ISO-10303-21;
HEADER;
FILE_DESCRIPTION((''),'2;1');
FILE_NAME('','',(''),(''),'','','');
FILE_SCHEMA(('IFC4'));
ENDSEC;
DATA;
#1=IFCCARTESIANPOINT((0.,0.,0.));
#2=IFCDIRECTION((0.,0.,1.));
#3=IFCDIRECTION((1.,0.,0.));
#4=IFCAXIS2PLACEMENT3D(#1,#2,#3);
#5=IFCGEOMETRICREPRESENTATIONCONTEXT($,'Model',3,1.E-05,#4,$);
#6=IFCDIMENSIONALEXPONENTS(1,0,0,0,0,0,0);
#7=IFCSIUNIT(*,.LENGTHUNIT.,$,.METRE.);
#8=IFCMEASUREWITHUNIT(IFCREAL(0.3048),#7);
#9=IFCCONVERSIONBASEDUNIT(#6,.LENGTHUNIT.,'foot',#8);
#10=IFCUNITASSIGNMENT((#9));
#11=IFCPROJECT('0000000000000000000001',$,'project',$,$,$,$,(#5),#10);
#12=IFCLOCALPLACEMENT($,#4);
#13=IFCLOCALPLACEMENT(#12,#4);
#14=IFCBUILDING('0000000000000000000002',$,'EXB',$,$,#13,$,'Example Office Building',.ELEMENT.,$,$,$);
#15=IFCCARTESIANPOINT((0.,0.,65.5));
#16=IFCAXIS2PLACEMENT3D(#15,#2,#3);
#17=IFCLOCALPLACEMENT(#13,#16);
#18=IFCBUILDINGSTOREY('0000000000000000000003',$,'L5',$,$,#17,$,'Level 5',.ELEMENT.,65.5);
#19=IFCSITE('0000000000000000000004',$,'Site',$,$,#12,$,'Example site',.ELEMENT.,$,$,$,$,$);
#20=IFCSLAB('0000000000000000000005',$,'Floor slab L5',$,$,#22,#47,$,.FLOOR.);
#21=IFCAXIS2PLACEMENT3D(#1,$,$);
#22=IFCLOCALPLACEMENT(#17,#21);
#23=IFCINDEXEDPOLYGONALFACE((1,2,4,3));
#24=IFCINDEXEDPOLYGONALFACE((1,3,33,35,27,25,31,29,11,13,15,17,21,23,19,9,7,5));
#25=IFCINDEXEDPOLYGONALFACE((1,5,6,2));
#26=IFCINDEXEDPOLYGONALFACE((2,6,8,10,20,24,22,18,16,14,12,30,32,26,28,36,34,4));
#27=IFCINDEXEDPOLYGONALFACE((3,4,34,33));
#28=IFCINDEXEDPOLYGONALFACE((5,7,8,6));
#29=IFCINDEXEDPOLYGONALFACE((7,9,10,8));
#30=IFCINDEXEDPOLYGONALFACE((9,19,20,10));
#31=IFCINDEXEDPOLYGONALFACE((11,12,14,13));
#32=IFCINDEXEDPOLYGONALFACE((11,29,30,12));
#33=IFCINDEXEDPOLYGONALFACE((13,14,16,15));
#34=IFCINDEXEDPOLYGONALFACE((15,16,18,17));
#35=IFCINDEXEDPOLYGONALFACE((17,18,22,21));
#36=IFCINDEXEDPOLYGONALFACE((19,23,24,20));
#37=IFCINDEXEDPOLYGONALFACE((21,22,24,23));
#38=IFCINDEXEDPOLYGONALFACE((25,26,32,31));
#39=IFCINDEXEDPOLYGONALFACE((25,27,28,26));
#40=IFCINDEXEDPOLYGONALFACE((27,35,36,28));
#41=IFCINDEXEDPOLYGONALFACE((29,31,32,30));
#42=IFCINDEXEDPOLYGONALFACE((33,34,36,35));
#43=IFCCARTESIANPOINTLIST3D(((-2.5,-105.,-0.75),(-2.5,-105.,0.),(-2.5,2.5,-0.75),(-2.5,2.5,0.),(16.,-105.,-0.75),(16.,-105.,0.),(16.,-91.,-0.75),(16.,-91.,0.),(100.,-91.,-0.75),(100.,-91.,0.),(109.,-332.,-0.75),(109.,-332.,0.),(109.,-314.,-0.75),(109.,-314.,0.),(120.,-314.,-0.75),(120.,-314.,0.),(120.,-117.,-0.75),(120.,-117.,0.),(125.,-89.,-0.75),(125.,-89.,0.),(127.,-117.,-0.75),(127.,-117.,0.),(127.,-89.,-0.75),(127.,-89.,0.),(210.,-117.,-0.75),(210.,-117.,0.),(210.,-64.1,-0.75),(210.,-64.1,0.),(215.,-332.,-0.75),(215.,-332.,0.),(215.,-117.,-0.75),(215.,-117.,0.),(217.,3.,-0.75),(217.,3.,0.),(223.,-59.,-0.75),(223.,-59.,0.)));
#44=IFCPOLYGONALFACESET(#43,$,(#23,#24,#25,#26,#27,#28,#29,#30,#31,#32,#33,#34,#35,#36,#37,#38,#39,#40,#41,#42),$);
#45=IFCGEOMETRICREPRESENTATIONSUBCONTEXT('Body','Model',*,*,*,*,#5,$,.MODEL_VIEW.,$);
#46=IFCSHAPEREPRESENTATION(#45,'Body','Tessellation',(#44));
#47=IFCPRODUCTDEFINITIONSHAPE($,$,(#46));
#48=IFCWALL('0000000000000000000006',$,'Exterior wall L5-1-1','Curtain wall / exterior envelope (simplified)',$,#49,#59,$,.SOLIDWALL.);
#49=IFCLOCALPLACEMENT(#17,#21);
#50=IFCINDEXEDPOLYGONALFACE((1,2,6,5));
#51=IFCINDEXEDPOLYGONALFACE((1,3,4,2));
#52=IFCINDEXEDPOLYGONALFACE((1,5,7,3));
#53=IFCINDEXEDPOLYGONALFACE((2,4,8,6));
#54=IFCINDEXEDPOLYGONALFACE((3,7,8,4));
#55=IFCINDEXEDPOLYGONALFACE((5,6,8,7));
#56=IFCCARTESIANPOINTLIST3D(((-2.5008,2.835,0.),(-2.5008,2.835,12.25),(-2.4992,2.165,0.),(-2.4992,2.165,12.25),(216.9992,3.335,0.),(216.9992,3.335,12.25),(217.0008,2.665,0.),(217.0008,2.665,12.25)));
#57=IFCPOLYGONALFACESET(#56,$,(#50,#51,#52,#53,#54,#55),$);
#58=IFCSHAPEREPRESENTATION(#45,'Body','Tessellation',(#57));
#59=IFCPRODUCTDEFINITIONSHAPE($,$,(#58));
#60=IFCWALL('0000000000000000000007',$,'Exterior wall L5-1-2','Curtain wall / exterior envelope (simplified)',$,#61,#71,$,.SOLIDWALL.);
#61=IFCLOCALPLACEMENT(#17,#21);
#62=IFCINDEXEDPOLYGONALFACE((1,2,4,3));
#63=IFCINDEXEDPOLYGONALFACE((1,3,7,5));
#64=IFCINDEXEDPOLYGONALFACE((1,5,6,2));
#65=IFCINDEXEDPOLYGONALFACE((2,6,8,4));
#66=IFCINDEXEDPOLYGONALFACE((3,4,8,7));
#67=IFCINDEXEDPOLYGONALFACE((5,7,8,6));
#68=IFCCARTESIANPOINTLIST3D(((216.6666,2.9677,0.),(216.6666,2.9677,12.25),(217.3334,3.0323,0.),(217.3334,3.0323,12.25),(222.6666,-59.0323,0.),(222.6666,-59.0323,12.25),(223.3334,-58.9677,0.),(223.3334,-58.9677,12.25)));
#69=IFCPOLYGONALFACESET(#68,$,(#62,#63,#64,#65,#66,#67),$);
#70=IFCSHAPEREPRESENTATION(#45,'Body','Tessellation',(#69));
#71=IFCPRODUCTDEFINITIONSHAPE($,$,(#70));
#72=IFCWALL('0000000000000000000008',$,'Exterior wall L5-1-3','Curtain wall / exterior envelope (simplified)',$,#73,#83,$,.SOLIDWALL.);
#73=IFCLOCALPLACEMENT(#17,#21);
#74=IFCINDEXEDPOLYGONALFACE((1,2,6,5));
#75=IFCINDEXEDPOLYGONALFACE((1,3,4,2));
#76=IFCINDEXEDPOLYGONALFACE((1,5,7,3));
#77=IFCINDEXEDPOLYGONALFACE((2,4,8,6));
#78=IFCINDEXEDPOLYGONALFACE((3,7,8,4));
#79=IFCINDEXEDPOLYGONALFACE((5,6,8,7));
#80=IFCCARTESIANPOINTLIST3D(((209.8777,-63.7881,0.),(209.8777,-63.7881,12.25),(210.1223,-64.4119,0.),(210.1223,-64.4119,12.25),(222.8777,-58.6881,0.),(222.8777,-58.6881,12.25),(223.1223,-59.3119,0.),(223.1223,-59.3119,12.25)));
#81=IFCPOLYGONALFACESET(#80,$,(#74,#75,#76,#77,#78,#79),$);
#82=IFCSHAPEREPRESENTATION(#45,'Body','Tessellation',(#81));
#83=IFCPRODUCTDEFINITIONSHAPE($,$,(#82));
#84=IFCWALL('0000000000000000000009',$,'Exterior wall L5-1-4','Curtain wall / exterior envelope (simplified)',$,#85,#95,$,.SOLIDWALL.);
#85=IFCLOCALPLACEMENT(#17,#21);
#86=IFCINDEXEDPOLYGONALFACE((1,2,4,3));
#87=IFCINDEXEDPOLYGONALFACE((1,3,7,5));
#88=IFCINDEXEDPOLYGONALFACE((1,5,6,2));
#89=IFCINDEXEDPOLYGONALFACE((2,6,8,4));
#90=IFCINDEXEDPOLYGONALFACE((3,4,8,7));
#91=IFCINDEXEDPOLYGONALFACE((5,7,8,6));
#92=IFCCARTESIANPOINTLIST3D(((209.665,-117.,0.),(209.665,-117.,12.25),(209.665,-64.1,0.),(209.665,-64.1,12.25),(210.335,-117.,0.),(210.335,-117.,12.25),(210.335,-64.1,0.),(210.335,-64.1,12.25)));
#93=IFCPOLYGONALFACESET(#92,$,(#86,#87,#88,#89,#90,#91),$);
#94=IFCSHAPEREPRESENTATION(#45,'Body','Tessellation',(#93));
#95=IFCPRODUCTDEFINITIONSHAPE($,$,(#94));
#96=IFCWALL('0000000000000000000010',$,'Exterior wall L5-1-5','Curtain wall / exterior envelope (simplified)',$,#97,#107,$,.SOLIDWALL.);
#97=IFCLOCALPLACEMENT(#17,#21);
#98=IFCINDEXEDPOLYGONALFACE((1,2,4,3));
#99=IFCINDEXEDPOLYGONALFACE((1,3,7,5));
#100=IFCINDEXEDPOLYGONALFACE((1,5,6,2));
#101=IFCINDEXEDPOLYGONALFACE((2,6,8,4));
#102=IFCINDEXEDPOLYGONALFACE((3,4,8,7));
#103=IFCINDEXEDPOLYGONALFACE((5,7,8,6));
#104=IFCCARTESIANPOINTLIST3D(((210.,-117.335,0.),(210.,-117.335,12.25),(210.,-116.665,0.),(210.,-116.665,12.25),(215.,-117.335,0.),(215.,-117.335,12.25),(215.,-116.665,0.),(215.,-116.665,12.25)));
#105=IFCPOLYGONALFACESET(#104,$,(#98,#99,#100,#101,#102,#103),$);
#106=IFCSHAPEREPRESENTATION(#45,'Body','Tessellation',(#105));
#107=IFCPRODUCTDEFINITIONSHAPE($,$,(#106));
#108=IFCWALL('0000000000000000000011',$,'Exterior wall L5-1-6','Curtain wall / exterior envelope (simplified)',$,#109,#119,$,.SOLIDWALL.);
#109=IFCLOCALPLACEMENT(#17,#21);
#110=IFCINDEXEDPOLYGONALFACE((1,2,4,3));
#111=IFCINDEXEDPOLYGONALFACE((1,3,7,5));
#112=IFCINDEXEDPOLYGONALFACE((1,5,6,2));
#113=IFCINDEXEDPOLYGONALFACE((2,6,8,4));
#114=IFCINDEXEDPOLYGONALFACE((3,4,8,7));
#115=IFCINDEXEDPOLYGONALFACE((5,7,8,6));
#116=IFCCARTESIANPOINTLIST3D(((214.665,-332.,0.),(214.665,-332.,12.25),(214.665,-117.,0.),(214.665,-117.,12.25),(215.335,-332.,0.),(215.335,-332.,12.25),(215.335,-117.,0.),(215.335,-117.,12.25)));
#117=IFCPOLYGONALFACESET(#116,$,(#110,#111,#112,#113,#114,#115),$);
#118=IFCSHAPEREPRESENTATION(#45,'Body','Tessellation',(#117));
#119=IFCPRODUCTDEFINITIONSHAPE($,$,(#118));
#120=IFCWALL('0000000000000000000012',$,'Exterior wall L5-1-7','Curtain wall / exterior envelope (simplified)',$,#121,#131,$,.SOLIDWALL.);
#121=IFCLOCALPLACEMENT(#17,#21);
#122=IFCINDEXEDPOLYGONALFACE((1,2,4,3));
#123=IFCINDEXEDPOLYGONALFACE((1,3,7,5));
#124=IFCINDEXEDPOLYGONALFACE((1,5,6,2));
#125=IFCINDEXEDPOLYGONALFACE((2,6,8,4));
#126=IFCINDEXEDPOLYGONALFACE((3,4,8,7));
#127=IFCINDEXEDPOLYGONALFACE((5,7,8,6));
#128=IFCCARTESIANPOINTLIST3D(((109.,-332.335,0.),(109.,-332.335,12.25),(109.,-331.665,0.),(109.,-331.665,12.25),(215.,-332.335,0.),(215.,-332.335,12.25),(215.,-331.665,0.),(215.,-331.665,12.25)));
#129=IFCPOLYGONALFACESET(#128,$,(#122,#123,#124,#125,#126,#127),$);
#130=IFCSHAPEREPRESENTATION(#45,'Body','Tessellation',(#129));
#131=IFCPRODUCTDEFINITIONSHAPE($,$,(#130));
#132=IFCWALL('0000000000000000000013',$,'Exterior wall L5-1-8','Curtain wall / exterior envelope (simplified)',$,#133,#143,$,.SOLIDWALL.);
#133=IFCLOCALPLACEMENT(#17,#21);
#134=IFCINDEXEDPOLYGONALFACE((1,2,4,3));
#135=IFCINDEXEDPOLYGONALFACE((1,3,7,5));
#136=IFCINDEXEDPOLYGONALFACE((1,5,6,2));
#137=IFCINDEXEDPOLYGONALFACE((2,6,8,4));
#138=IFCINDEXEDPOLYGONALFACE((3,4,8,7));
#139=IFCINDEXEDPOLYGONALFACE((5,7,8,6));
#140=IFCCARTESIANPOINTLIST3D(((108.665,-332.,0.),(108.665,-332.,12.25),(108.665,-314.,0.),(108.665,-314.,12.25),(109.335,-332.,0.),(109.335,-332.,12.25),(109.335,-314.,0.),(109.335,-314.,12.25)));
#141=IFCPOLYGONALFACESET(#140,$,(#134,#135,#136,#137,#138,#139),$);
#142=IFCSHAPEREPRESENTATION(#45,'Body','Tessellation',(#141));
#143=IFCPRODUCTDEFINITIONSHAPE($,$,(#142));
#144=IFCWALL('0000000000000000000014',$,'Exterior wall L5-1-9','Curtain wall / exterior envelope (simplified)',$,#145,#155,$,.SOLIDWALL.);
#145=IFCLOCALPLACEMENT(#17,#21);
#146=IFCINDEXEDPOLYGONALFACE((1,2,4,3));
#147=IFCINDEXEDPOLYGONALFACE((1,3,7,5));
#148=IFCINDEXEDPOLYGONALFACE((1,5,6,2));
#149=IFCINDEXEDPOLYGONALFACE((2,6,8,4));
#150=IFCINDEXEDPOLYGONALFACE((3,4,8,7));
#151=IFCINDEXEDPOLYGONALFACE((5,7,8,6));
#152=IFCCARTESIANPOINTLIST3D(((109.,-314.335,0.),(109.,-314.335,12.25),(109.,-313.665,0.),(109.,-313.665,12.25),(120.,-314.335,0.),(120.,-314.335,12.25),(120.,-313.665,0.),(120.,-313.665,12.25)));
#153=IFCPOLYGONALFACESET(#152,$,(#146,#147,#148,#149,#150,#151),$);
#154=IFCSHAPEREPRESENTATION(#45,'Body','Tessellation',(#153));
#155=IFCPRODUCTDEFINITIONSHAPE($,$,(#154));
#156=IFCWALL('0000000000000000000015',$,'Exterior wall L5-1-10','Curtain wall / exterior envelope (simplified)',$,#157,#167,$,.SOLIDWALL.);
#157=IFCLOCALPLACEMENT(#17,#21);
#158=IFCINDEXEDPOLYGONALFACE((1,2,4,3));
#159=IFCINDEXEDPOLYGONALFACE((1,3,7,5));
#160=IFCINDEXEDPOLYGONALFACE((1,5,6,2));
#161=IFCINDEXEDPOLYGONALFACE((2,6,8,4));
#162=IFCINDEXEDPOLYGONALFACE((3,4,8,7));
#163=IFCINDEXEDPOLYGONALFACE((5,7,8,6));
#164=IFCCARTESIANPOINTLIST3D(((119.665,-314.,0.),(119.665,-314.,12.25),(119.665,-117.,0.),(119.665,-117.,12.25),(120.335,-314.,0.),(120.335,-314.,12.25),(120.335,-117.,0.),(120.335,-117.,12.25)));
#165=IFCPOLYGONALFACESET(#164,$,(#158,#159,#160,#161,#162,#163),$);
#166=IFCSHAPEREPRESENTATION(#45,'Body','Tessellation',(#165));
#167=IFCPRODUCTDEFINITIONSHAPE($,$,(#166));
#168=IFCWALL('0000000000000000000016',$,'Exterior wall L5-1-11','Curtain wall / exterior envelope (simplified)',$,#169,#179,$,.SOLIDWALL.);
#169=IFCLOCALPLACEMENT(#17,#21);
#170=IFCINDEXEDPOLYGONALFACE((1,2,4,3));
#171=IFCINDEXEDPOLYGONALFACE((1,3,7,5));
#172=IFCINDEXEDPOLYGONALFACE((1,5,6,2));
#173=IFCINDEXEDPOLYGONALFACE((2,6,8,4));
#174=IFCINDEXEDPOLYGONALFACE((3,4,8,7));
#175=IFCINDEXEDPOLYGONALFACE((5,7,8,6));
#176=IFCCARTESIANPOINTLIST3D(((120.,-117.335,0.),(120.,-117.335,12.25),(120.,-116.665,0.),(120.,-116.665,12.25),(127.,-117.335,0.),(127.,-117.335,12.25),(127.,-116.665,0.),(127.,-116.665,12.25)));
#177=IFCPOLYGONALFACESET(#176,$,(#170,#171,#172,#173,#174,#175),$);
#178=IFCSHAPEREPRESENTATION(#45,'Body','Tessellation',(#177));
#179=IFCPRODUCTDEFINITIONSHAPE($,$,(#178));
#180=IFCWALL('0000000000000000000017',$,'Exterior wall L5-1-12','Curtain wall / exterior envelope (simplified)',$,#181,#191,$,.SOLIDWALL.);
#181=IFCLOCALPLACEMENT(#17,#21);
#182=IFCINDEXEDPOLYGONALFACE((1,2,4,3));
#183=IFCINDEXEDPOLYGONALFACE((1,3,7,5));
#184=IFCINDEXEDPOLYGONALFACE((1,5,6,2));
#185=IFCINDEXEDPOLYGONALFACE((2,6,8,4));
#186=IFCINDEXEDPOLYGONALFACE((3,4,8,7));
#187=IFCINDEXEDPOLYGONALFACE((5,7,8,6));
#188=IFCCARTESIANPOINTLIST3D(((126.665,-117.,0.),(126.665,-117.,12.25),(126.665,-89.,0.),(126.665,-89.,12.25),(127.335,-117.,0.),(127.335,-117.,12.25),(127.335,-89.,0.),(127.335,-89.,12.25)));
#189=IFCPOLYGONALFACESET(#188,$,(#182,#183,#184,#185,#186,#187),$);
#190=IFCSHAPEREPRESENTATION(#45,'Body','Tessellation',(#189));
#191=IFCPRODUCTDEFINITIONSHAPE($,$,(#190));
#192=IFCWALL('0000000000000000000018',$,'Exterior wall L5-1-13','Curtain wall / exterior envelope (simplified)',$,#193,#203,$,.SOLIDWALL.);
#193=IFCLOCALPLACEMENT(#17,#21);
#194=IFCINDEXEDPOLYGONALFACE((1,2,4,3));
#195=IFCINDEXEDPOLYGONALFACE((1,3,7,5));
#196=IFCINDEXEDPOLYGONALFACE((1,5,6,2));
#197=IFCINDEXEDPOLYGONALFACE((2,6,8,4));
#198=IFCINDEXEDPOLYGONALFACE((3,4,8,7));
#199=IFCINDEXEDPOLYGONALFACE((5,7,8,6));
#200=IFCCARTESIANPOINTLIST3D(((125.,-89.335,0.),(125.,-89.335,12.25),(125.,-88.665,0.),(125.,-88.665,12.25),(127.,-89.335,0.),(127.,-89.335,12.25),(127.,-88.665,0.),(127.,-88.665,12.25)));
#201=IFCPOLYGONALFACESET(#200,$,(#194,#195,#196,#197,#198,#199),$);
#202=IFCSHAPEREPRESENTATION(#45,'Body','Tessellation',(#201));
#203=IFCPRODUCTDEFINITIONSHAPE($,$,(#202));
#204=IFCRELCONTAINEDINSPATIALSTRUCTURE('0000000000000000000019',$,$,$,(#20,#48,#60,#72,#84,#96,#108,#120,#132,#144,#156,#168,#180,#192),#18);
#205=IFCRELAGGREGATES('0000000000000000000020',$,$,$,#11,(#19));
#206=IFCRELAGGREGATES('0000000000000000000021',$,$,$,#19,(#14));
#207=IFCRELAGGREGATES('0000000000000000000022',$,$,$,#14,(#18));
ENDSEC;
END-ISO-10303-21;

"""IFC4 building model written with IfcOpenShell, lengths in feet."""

from ifc_helpers import new_model, entity, si_unit, converted_unit, frame, frame_2d, origin, origin_with_axes, place, context, subcontext, project, spatial, polyline, rectangle, outline, extrude, element, save


model = new_model("IFC4")

# Units and contexts
model_context = context("Model", 3, precision=1e-05, world=origin_with_axes())
body_context = subcontext(model_context, "Body", "Model", "MODEL_VIEW")
ifc_project = project(units=[converted_unit("LENGTHUNIT", "foot", entity("IfcReal", 0.3048), si_unit("LENGTHUNIT", "METRE"), dimensions=[1, 0, 0, 0, 0, 0, 0])], contexts=[model_context])

# Site, building, storey
site_placement = place(None, origin_with_axes())
site = spatial("IfcSite", under=ifc_project, at=site_placement, Name="Site", LongName="Example site", CompositionType="ELEMENT")
building_placement = place(site_placement, origin_with_axes())
building = spatial("IfcBuilding", under=site, at=building_placement, Name="EXB", LongName="Example Office Building", CompositionType="ELEMENT")
storey_placement = place(building_placement, frame((0.0, 0.0, 65.5), z_axis=(0.0, 0.0, 1.0), x_axis=(1.0, 0.0, 0.0)))
storey = spatial("IfcBuildingStorey", under=building, at=storey_placement, Name="L5", LongName="Level 5", CompositionType="ELEMENT", Elevation=65.5)

# Slab
slab_placement = place(storey_placement, origin_with_axes())
element("IfcSlab", 1, at=slab_placement, inside=storey, Name="Floor slab L5", PredefinedType="FLOOR", context=body_context, shape_type="SweptSolid", body=[
    extrude(outline(polyline([(-2.5, 2.5), (217.0, 3.0), (223.0, -59.0), (210.0, -64.1), (210.0, -117.0), (215.0, -117.0), (215.0, -332.0), (109.0, -332.0), (109.0, -314.0), (120.0, -314.0), (120.0, -117.0), (127.0, -117.0), (127.0, -89.0), (125.0, -89.0), (100.0, -91.0), (16.0, -91.0), (16.0, -105.0), (-2.5, -105.0), (-2.5, 2.5)])), frame((0.0, 0.0, -0.75)), (0.0, 0.0, 1.0), 0.75),
])

# Walls
wall_1_placement = place(storey_placement, frame((-2.5, 2.5, 0.0), z_axis=(0.0, 0.0, 1.0), x_axis=(0.999997, 0.002278, 0.0)))
element("IfcWall", 2, at=wall_1_placement, inside=storey, Name="Exterior wall L5-1-1", Description="Curtain wall / exterior envelope (simplified)", PredefinedType="SOLIDWALL", context=body_context, shape_type="SweptSolid", body=[
    extrude(rectangle(XDim=219.5006, YDim=0.67, at=frame_2d((109.7503, 0.0))), origin(), (0.0, 0.0, 1.0), 12.25),
])
wall_2_placement = place(storey_placement, frame((217.0, 3.0, 0.0), z_axis=(0.0, 0.0, 1.0), x_axis=(0.096324, -0.99535, 0.0)))
element("IfcWall", 3, at=wall_2_placement, inside=storey, Name="Exterior wall L5-1-2", Description="Curtain wall / exterior envelope (simplified)", PredefinedType="SOLIDWALL", context=body_context, shape_type="SweptSolid", body=[
    extrude(rectangle(XDim=62.2896, YDim=0.67, at=frame_2d((31.1448, 0.0))), origin(), (0.0, 0.0, 1.0), 12.25),
])
wall_3_placement = place(storey_placement, frame((223.0, -59.0, 0.0), z_axis=(0.0, 0.0, 1.0), x_axis=(-0.930925, -0.365209, 0.0)))
element("IfcWall", 4, at=wall_3_placement, inside=storey, Name="Exterior wall L5-1-3", Description="Curtain wall / exterior envelope (simplified)", PredefinedType="SOLIDWALL", context=body_context, shape_type="SweptSolid", body=[
    extrude(rectangle(XDim=13.9646, YDim=0.67, at=frame_2d((6.9823, 0.0))), origin(), (0.0, 0.0, 1.0), 12.25),
])
wall_4_placement = place(storey_placement, frame((210.0, -64.1, 0.0), z_axis=(0.0, 0.0, 1.0), x_axis=(0.0, -1.0, 0.0)))
element("IfcWall", 5, at=wall_4_placement, inside=storey, Name="Exterior wall L5-1-4", Description="Curtain wall / exterior envelope (simplified)", PredefinedType="SOLIDWALL", context=body_context, shape_type="SweptSolid", body=[
    extrude(rectangle(XDim=52.9, YDim=0.67, at=frame_2d((26.45, 0.0))), origin(), (0.0, 0.0, 1.0), 12.25),
])
wall_5_placement = place(storey_placement, frame((210.0, -117.0, 0.0), z_axis=(0.0, 0.0, 1.0), x_axis=(1.0, 0.0, 0.0)))
element("IfcWall", 6, at=wall_5_placement, inside=storey, Name="Exterior wall L5-1-5", Description="Curtain wall / exterior envelope (simplified)", PredefinedType="SOLIDWALL", context=body_context, shape_type="SweptSolid", body=[
    extrude(rectangle(XDim=5.0, YDim=0.67, at=frame_2d((2.5, 0.0))), origin(), (0.0, 0.0, 1.0), 12.25),
])
wall_6_placement = place(storey_placement, frame((215.0, -117.0, 0.0), z_axis=(0.0, 0.0, 1.0), x_axis=(0.0, -1.0, 0.0)))
element("IfcWall", 7, at=wall_6_placement, inside=storey, Name="Exterior wall L5-1-6", Description="Curtain wall / exterior envelope (simplified)", PredefinedType="SOLIDWALL", context=body_context, shape_type="SweptSolid", body=[
    extrude(rectangle(XDim=215.0, YDim=0.67, at=frame_2d((107.5, 0.0))), origin(), (0.0, 0.0, 1.0), 12.25),
])
wall_7_placement = place(storey_placement, frame((215.0, -332.0, 0.0), z_axis=(0.0, 0.0, 1.0), x_axis=(-1.0, 0.0, 0.0)))
element("IfcWall", 8, at=wall_7_placement, inside=storey, Name="Exterior wall L5-1-7", Description="Curtain wall / exterior envelope (simplified)", PredefinedType="SOLIDWALL", context=body_context, shape_type="SweptSolid", body=[
    extrude(rectangle(XDim=106.0, YDim=0.67, at=frame_2d((53.0, 0.0))), origin(), (0.0, 0.0, 1.0), 12.25),
])
wall_8_placement = place(storey_placement, frame((109.0, -332.0, 0.0), z_axis=(0.0, 0.0, 1.0), x_axis=(0.0, 1.0, 0.0)))
element("IfcWall", 9, at=wall_8_placement, inside=storey, Name="Exterior wall L5-1-8", Description="Curtain wall / exterior envelope (simplified)", PredefinedType="SOLIDWALL", context=body_context, shape_type="SweptSolid", body=[
    extrude(rectangle(XDim=18.0, YDim=0.67, at=frame_2d((9.0, 0.0))), origin(), (0.0, 0.0, 1.0), 12.25),
])
wall_9_placement = place(storey_placement, frame((109.0, -314.0, 0.0), z_axis=(0.0, 0.0, 1.0), x_axis=(1.0, 0.0, 0.0)))
element("IfcWall", 10, at=wall_9_placement, inside=storey, Name="Exterior wall L5-1-9", Description="Curtain wall / exterior envelope (simplified)", PredefinedType="SOLIDWALL", context=body_context, shape_type="SweptSolid", body=[
    extrude(rectangle(XDim=11.0, YDim=0.67, at=frame_2d((5.5, 0.0))), origin(), (0.0, 0.0, 1.0), 12.25),
])
wall_10_placement = place(storey_placement, frame((120.0, -314.0, 0.0), z_axis=(0.0, 0.0, 1.0), x_axis=(0.0, 1.0, 0.0)))
element("IfcWall", 11, at=wall_10_placement, inside=storey, Name="Exterior wall L5-1-10", Description="Curtain wall / exterior envelope (simplified)", PredefinedType="SOLIDWALL", context=body_context, shape_type="SweptSolid", body=[
    extrude(rectangle(XDim=197.0, YDim=0.67, at=frame_2d((98.5, 0.0))), origin(), (0.0, 0.0, 1.0), 12.25),
])
wall_11_placement = place(storey_placement, frame((120.0, -117.0, 0.0), z_axis=(0.0, 0.0, 1.0), x_axis=(1.0, 0.0, 0.0)))
element("IfcWall", 12, at=wall_11_placement, inside=storey, Name="Exterior wall L5-1-11", Description="Curtain wall / exterior envelope (simplified)", PredefinedType="SOLIDWALL", context=body_context, shape_type="SweptSolid", body=[
    extrude(rectangle(XDim=7.0, YDim=0.67, at=frame_2d((3.5, 0.0))), origin(), (0.0, 0.0, 1.0), 12.25),
])
wall_12_placement = place(storey_placement, frame((127.0, -117.0, 0.0), z_axis=(0.0, 0.0, 1.0), x_axis=(0.0, 1.0, 0.0)))
element("IfcWall", 13, at=wall_12_placement, inside=storey, Name="Exterior wall L5-1-12", Description="Curtain wall / exterior envelope (simplified)", PredefinedType="SOLIDWALL", context=body_context, shape_type="SweptSolid", body=[
    extrude(rectangle(XDim=28.0, YDim=0.67, at=frame_2d((14.0, 0.0))), origin(), (0.0, 0.0, 1.0), 12.25),
])
wall_13_placement = place(storey_placement, frame((127.0, -89.0, 0.0), z_axis=(0.0, 0.0, 1.0), x_axis=(-1.0, 0.0, 0.0)))
element("IfcWall", 14, at=wall_13_placement, inside=storey, Name="Exterior wall L5-1-13", Description="Curtain wall / exterior envelope (simplified)", PredefinedType="SOLIDWALL", context=body_context, shape_type="SweptSolid", body=[
    extrude(rectangle(XDim=2.0, YDim=0.67, at=frame_2d((1.0, 0.0))), origin(), (0.0, 0.0, 1.0), 12.25),
])

save(model, "model.ifc")
